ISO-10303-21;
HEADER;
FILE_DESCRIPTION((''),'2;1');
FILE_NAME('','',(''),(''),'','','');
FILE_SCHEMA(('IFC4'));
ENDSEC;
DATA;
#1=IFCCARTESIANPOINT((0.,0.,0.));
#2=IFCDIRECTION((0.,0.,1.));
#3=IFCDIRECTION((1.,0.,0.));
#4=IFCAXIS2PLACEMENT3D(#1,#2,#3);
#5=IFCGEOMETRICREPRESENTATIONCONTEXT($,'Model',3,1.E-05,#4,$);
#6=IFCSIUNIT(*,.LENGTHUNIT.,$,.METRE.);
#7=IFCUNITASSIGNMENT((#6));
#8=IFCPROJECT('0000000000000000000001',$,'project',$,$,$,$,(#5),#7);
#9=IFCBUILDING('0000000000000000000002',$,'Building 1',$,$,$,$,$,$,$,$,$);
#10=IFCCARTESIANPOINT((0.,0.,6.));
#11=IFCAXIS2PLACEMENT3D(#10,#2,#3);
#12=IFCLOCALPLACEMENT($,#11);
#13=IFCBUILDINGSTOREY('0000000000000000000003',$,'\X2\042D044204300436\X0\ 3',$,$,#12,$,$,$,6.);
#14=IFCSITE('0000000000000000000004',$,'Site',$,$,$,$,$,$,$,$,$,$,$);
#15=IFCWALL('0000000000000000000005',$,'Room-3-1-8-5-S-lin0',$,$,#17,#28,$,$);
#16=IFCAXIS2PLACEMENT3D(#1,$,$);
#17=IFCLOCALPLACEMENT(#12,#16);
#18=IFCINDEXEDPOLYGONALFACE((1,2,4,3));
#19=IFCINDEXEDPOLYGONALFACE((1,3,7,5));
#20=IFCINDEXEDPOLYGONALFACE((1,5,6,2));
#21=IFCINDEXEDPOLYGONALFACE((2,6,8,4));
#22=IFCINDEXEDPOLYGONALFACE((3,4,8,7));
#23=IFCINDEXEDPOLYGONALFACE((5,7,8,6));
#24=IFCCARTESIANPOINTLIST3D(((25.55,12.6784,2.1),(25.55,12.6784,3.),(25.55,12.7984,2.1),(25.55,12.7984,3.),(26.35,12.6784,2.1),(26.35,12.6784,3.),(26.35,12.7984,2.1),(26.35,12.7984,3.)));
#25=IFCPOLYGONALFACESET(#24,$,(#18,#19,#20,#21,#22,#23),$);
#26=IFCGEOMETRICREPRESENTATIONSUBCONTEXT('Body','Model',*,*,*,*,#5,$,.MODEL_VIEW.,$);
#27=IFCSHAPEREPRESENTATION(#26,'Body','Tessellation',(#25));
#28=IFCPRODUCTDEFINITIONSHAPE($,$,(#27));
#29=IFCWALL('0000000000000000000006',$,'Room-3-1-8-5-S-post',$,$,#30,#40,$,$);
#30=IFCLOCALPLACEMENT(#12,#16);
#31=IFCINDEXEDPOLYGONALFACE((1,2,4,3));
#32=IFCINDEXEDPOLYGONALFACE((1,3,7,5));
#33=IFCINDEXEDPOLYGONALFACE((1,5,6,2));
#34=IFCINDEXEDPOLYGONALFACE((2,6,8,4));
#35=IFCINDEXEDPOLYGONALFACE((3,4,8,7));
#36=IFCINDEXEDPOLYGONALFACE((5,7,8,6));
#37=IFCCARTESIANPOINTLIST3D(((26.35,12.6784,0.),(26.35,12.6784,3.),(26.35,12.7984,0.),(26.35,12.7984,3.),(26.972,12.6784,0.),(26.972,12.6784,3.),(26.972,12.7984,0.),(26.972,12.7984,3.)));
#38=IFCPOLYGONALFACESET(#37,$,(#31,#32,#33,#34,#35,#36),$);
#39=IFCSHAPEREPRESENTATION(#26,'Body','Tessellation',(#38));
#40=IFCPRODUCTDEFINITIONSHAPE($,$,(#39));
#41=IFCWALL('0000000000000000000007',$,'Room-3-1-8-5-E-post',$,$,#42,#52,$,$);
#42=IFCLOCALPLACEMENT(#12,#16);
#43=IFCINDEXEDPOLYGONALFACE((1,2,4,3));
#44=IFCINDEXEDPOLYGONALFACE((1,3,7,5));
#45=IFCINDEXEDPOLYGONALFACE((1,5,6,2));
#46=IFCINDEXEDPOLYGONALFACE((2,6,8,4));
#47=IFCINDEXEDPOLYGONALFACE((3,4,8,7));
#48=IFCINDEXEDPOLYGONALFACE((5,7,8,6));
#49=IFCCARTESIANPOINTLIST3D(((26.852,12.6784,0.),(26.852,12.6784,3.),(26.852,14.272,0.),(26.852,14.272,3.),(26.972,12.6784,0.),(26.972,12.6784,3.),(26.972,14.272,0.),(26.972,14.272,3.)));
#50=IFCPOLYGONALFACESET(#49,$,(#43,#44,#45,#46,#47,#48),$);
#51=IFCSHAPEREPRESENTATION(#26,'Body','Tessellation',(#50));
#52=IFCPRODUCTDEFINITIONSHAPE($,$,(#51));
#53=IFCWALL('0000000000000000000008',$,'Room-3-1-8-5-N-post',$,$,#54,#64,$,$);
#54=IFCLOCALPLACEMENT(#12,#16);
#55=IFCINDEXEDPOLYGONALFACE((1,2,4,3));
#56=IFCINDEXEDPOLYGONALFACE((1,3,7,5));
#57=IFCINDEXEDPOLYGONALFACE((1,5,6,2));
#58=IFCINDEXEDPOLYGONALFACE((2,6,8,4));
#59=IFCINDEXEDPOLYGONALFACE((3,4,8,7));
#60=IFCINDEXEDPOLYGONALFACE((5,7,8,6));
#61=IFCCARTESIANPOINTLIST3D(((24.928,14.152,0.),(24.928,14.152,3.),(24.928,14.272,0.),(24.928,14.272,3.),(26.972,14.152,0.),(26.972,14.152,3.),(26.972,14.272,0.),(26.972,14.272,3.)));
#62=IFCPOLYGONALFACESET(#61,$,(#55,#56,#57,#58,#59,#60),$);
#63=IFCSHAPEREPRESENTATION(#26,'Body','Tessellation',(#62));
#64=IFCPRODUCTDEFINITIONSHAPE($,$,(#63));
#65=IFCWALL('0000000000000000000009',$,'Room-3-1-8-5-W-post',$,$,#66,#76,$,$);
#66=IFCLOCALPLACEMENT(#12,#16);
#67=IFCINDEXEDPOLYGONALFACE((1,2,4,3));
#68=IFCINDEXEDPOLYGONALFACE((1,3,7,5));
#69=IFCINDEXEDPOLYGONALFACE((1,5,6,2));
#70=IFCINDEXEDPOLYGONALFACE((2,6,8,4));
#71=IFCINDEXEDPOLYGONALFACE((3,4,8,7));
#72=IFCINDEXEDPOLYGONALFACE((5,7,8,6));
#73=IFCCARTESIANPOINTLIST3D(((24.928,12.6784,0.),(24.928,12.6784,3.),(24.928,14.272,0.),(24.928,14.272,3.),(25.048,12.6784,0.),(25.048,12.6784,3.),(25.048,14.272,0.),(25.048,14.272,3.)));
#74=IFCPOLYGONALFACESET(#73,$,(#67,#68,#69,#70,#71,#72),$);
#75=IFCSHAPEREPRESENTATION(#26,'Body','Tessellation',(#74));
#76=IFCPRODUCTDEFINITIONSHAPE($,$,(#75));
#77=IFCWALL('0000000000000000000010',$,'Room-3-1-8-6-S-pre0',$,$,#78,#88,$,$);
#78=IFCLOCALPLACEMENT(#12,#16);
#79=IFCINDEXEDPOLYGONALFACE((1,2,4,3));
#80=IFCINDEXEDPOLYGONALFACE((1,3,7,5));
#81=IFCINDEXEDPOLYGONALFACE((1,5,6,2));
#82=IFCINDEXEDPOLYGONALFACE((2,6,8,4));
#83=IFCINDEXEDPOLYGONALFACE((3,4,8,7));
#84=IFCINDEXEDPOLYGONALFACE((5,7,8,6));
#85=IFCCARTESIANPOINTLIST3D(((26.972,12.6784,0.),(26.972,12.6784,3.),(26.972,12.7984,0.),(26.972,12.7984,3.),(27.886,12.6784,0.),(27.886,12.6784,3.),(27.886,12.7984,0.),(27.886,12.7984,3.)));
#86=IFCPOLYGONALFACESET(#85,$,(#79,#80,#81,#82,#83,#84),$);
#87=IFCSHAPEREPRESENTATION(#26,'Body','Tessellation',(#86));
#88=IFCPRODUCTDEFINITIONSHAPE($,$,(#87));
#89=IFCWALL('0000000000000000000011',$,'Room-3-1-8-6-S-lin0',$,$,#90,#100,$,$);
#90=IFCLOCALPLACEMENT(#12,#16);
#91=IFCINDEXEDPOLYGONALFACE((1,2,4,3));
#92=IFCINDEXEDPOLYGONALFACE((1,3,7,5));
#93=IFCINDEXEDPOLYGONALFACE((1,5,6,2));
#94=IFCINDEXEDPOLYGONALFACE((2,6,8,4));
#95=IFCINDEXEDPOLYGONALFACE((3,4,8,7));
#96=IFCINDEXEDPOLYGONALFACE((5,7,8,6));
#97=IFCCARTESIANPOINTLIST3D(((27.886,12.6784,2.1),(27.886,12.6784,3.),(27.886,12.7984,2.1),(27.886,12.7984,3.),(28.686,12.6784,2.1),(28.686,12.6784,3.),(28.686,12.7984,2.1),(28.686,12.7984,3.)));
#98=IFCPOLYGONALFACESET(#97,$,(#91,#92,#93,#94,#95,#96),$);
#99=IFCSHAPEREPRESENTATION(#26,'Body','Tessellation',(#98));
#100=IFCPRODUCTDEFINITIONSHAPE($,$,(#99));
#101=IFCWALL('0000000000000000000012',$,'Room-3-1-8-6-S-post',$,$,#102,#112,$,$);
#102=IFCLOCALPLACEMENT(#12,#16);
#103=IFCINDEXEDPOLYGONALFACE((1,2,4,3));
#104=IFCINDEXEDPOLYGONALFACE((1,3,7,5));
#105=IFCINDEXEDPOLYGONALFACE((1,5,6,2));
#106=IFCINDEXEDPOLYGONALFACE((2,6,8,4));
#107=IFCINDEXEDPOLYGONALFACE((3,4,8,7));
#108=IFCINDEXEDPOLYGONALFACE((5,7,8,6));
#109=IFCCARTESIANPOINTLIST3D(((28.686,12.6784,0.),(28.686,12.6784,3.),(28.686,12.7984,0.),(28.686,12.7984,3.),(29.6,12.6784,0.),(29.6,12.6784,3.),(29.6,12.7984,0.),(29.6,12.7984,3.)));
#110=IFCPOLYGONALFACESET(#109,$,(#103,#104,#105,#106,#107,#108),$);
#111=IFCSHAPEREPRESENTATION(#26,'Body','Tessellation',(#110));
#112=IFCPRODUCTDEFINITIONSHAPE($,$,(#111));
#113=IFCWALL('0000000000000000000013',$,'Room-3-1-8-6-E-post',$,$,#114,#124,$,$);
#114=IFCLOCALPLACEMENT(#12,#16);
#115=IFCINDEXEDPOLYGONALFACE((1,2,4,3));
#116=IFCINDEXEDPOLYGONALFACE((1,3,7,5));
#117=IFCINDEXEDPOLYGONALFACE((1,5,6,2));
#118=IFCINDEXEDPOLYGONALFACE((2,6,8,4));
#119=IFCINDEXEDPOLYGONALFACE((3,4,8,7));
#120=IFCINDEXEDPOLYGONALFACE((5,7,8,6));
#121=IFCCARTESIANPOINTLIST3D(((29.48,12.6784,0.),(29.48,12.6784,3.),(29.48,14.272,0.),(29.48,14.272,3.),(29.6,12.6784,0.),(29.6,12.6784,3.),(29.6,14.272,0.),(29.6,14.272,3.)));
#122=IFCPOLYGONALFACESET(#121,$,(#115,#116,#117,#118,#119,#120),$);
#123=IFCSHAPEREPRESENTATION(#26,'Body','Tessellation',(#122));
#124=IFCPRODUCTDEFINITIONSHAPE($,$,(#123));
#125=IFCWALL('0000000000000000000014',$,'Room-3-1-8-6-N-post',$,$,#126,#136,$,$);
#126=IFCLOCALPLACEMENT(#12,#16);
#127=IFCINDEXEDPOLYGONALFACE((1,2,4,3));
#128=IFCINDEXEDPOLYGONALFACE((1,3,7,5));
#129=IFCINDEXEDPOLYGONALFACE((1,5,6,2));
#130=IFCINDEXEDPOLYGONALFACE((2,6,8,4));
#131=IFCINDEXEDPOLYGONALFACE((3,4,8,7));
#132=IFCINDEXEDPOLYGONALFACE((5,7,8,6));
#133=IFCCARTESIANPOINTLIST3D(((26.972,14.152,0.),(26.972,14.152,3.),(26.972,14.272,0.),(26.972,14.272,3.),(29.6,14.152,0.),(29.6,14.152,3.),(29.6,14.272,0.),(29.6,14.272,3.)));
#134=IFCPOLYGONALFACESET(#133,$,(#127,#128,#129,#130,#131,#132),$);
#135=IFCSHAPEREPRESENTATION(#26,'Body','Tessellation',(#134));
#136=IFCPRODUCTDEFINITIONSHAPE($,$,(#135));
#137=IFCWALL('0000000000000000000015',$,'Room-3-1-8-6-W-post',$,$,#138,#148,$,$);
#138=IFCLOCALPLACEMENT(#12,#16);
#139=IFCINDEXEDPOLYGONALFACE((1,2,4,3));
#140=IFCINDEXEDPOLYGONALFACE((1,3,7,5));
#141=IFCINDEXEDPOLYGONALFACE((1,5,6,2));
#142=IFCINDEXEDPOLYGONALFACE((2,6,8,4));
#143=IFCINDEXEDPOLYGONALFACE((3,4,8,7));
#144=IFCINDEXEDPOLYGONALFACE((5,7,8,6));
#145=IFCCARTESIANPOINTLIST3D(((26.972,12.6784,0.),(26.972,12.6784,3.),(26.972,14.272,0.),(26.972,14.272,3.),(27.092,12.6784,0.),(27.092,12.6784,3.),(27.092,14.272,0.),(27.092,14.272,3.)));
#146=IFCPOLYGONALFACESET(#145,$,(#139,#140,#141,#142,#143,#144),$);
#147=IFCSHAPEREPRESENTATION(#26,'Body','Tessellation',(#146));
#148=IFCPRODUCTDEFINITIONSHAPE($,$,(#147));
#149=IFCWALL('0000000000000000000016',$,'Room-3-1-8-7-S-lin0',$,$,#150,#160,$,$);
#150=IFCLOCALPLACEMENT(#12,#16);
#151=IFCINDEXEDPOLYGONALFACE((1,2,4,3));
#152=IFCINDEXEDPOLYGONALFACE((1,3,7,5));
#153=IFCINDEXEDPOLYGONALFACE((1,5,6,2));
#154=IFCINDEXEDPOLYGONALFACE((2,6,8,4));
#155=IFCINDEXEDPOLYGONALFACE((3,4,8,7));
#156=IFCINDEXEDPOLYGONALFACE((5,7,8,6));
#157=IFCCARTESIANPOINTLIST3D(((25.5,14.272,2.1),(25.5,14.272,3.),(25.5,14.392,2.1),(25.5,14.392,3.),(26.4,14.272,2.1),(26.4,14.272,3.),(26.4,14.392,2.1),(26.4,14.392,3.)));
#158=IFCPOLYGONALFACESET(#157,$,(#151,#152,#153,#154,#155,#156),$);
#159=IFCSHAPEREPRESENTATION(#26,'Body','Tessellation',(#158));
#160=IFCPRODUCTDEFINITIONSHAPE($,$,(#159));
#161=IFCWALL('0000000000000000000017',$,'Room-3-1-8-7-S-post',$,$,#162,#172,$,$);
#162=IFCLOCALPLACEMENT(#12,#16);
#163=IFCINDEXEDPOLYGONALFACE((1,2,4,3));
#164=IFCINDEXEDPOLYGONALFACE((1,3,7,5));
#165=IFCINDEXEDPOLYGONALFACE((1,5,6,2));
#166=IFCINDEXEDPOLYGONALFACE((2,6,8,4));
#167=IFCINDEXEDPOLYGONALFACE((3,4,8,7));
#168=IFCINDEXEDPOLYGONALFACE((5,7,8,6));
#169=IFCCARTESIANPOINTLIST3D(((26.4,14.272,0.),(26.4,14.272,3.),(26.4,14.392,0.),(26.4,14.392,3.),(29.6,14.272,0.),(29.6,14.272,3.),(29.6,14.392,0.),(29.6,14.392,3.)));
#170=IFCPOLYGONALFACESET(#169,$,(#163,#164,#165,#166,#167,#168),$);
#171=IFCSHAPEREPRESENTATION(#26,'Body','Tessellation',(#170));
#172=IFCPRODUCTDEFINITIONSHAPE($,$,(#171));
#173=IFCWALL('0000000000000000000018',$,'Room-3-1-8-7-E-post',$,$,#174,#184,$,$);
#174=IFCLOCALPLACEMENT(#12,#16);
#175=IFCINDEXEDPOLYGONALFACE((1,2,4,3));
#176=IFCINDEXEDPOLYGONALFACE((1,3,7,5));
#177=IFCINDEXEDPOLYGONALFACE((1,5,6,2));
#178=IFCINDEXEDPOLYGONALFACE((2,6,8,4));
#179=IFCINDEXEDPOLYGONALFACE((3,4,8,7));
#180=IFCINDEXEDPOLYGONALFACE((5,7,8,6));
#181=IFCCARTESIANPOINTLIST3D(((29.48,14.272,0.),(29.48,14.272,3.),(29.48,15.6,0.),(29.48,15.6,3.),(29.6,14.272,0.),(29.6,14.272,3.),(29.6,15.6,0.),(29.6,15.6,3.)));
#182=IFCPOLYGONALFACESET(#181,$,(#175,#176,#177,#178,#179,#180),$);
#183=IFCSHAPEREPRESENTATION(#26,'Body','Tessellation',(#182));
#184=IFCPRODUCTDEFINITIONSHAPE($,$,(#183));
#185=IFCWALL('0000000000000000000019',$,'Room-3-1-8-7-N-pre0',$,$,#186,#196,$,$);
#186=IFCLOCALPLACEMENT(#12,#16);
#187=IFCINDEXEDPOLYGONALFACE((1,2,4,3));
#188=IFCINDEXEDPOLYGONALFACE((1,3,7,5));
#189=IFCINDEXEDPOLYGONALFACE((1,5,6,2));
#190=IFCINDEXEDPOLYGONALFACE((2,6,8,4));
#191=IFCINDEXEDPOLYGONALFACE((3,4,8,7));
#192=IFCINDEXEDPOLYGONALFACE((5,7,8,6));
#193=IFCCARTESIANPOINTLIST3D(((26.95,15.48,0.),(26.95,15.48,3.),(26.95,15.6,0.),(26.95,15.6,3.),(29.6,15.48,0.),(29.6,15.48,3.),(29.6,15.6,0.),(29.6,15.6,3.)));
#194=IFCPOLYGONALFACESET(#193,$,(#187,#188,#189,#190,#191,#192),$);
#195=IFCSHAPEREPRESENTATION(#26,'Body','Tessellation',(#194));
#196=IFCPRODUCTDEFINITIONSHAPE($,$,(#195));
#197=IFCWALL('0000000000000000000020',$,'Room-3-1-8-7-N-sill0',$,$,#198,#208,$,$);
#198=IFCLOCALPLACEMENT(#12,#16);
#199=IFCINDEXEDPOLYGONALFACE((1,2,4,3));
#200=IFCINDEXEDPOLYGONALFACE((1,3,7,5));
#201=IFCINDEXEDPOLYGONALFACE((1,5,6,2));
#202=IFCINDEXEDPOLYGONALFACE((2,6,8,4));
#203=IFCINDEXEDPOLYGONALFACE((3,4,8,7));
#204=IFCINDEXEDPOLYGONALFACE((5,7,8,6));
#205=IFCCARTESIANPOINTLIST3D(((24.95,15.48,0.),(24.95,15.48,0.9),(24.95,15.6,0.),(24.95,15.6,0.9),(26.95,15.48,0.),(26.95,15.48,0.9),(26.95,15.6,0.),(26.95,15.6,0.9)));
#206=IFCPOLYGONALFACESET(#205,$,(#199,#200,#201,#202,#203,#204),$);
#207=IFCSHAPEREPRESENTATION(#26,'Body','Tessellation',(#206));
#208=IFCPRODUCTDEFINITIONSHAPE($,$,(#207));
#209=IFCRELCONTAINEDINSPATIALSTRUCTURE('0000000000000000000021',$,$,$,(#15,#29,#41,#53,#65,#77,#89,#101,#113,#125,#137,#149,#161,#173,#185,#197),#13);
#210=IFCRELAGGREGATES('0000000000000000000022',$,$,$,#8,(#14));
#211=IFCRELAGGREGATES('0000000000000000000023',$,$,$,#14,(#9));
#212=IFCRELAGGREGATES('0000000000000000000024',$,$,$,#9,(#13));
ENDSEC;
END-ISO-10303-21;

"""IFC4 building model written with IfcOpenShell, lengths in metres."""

from ifc_helpers import new_model, si_unit, frame, origin_with_axes, place, context, subcontext, project, spatial, indexed_curve, outline, extrude, element, save


model = new_model("IFC4")

# Units and contexts
model_context = context("Model", 3, precision=1e-05, world=origin_with_axes())
body_context = subcontext(model_context, "Body", "Model", "MODEL_VIEW")
ifc_project = project(units=[si_unit("LENGTHUNIT", "METRE")], contexts=[model_context])

# Site, building, storey
site = spatial("IfcSite", under=ifc_project, Name="Site")
building = spatial("IfcBuilding", under=site, Name="Building 1")
storey_placement = place(None, frame((0.0, 0.0, 6.0), z_axis=(0.0, 0.0, 1.0), x_axis=(1.0, 0.0, 0.0)))
storey = spatial("IfcBuildingStorey", under=building, at=storey_placement, Name="Этаж 3", Elevation=6.0)

# Walls
wall_1_placement = place(storey_placement, frame((25.55, 12.6784, 2.1), z_axis=(0.0, 0.0, 1.0), x_axis=(1.0, 0.0, 0.0)))
element("IfcWall", 1, at=wall_1_placement, inside=storey, Name="Room-3-1-8-5-S-lin0", context=body_context, shape_type="SweptSolid", body=[
    extrude(outline(indexed_curve([(0.0, 0.0), (0.0, 0.12), (0.8, 0.12), (0.8, 0.0), (0.0, 0.0)], self_intersect=False)), origin_with_axes(), (0.0, 0.0, 1.0), 0.9),
])
wall_2_placement = place(storey_placement, frame((26.35, 12.6784, 0.0), z_axis=(0.0, 0.0, 1.0), x_axis=(1.0, 0.0, 0.0)))
element("IfcWall", 2, at=wall_2_placement, inside=storey, Name="Room-3-1-8-5-S-post", context=body_context, shape_type="SweptSolid", body=[
    extrude(outline(indexed_curve([(0.0, 0.0), (0.0, 0.12), (0.622, 0.12), (0.622, 0.0), (0.0, 0.0)], self_intersect=False)), origin_with_axes(), (0.0, 0.0, 1.0), 3.0),
])
wall_3_placement = place(storey_placement, frame((26.972, 12.6784, 0.0), z_axis=(0.0, 0.0, 1.0), x_axis=(0.0, 1.0, 0.0)))
element("IfcWall", 3, at=wall_3_placement, inside=storey, Name="Room-3-1-8-5-E-post", context=body_context, shape_type="SweptSolid", body=[
    extrude(outline(indexed_curve([(0.0, 0.0), (0.0, 0.12), (1.5936, 0.12), (1.5936, 0.0), (0.0, 0.0)], self_intersect=False)), origin_with_axes(), (0.0, 0.0, 1.0), 3.0),
])
wall_4_placement = place(storey_placement, frame((26.972, 14.272, 0.0), z_axis=(0.0, 0.0, 1.0), x_axis=(-1.0, 0.0, 0.0)))
element("IfcWall", 4, at=wall_4_placement, inside=storey, Name="Room-3-1-8-5-N-post", context=body_context, shape_type="SweptSolid", body=[
    extrude(outline(indexed_curve([(0.0, 0.0), (0.0, 0.12), (2.044, 0.12), (2.044, 0.0), (0.0, 0.0)], self_intersect=False)), origin_with_axes(), (0.0, 0.0, 1.0), 3.0),
])
wall_5_placement = place(storey_placement, frame((24.928, 14.272, 0.0), z_axis=(0.0, 0.0, 1.0), x_axis=(0.0, -1.0, 0.0)))
element("IfcWall", 5, at=wall_5_placement, inside=storey, Name="Room-3-1-8-5-W-post", context=body_context, shape_type="SweptSolid", body=[
    extrude(outline(indexed_curve([(0.0, 0.0), (0.0, 0.12), (1.5936, 0.12), (1.5936, 0.0), (0.0, 0.0)], self_intersect=False)), origin_with_axes(), (0.0, 0.0, 1.0), 3.0),
])
wall_6_placement = place(storey_placement, frame((26.972, 12.6784, 0.0), z_axis=(0.0, 0.0, 1.0), x_axis=(1.0, 0.0, 0.0)))
element("IfcWall", 6, at=wall_6_placement, inside=storey, Name="Room-3-1-8-6-S-pre0", context=body_context, shape_type="SweptSolid", body=[
    extrude(outline(indexed_curve([(0.0, 0.0), (0.0, 0.12), (0.914, 0.12), (0.914, 0.0), (0.0, 0.0)], self_intersect=False)), origin_with_axes(), (0.0, 0.0, 1.0), 3.0),
])
wall_7_placement = place(storey_placement, frame((27.886, 12.6784, 2.1), z_axis=(0.0, 0.0, 1.0), x_axis=(1.0, 0.0, 0.0)))
element("IfcWall", 7, at=wall_7_placement, inside=storey, Name="Room-3-1-8-6-S-lin0", context=body_context, shape_type="SweptSolid", body=[
    extrude(outline(indexed_curve([(0.0, 0.0), (0.0, 0.12), (0.8, 0.12), (0.8, 0.0), (0.0, 0.0)], self_intersect=False)), origin_with_axes(), (0.0, 0.0, 1.0), 0.9),
])
wall_8_placement = place(storey_placement, frame((28.686, 12.6784, 0.0), z_axis=(0.0, 0.0, 1.0), x_axis=(1.0, 0.0, 0.0)))
element("IfcWall", 8, at=wall_8_placement, inside=storey, Name="Room-3-1-8-6-S-post", context=body_context, shape_type="SweptSolid", body=[
    extrude(outline(indexed_curve([(0.0, 0.0), (0.0, 0.12), (0.914, 0.12), (0.914, 0.0), (0.0, 0.0)], self_intersect=False)), origin_with_axes(), (0.0, 0.0, 1.0), 3.0),
])
wall_9_placement = place(storey_placement, frame((29.6, 12.6784, 0.0), z_axis=(0.0, 0.0, 1.0), x_axis=(0.0, 1.0, 0.0)))
element("IfcWall", 9, at=wall_9_placement, inside=storey, Name="Room-3-1-8-6-E-post", context=body_context, shape_type="SweptSolid", body=[
    extrude(outline(indexed_curve([(0.0, 0.0), (0.0, 0.12), (1.5936, 0.12), (1.5936, 0.0), (0.0, 0.0)], self_intersect=False)), origin_with_axes(), (0.0, 0.0, 1.0), 3.0),
])
wall_10_placement = place(storey_placement, frame((29.6, 14.272, 0.0), z_axis=(0.0, 0.0, 1.0), x_axis=(-1.0, 0.0, 0.0)))
element("IfcWall", 10, at=wall_10_placement, inside=storey, Name="Room-3-1-8-6-N-post", context=body_context, shape_type="SweptSolid", body=[
    extrude(outline(indexed_curve([(0.0, 0.0), (0.0, 0.12), (2.628, 0.12), (2.628, 0.0), (0.0, 0.0)], self_intersect=False)), origin_with_axes(), (0.0, 0.0, 1.0), 3.0),
])
wall_11_placement = place(storey_placement, frame((26.972, 14.272, 0.0), z_axis=(0.0, 0.0, 1.0), x_axis=(0.0, -1.0, 0.0)))
element("IfcWall", 11, at=wall_11_placement, inside=storey, Name="Room-3-1-8-6-W-post", context=body_context, shape_type="SweptSolid", body=[
    extrude(outline(indexed_curve([(0.0, 0.0), (0.0, 0.12), (1.5936, 0.12), (1.5936, 0.0), (0.0, 0.0)], self_intersect=False)), origin_with_axes(), (0.0, 0.0, 1.0), 3.0),
])
wall_12_placement = place(storey_placement, frame((25.5, 14.272, 2.1), z_axis=(0.0, 0.0, 1.0), x_axis=(1.0, 0.0, 0.0)))
element("IfcWall", 12, at=wall_12_placement, inside=storey, Name="Room-3-1-8-7-S-lin0", context=body_context, shape_type="SweptSolid", body=[
    extrude(outline(indexed_curve([(0.0, 0.0), (0.0, 0.12), (0.9, 0.12), (0.9, 0.0), (0.0, 0.0)], self_intersect=False)), origin_with_axes(), (0.0, 0.0, 1.0), 0.9),
])
wall_13_placement = place(storey_placement, frame((26.4, 14.272, 0.0), z_axis=(0.0, 0.0, 1.0), x_axis=(1.0, 0.0, 0.0)))
element("IfcWall", 13, at=wall_13_placement, inside=storey, Name="Room-3-1-8-7-S-post", context=body_context, shape_type="SweptSolid", body=[
    extrude(outline(indexed_curve([(0.0, 0.0), (0.0, 0.12), (3.2, 0.12), (3.2, 0.0), (0.0, 0.0)], self_intersect=False)), origin_with_axes(), (0.0, 0.0, 1.0), 3.0),
])
wall_14_placement = place(storey_placement, frame((29.6, 14.272, 0.0), z_axis=(0.0, 0.0, 1.0), x_axis=(0.0, 1.0, 0.0)))
element("IfcWall", 14, at=wall_14_placement, inside=storey, Name="Room-3-1-8-7-E-post", context=body_context, shape_type="SweptSolid", body=[
    extrude(outline(indexed_curve([(0.0, 0.0), (0.0, 0.12), (1.328, 0.12), (1.328, 0.0), (0.0, 0.0)], self_intersect=False)), origin_with_axes(), (0.0, 0.0, 1.0), 3.0),
])
wall_15_placement = place(storey_placement, frame((29.6, 15.6, 0.0), z_axis=(0.0, 0.0, 1.0), x_axis=(-1.0, 0.0, 0.0)))
element("IfcWall", 15, at=wall_15_placement, inside=storey, Name="Room-3-1-8-7-N-pre0", context=body_context, shape_type="SweptSolid", body=[
    extrude(outline(indexed_curve([(0.0, 0.0), (0.0, 0.12), (2.65, 0.12), (2.65, 0.0), (0.0, 0.0)], self_intersect=False)), origin_with_axes(), (0.0, 0.0, 1.0), 3.0),
])
wall_16_placement = place(storey_placement, frame((26.95, 15.6, 0.0), z_axis=(0.0, 0.0, 1.0), x_axis=(-1.0, 0.0, 0.0)))
element("IfcWall", 16, at=wall_16_placement, inside=storey, Name="Room-3-1-8-7-N-sill0", context=body_context, shape_type="SweptSolid", body=[
    extrude(outline(indexed_curve([(0.0, 0.0), (0.0, 0.12), (2.0, 0.12), (2.0, 0.0), (0.0, 0.0)], self_intersect=False)), origin_with_axes(), (0.0, 0.0, 1.0), 0.9),
])

save(model, "model.ifc")
